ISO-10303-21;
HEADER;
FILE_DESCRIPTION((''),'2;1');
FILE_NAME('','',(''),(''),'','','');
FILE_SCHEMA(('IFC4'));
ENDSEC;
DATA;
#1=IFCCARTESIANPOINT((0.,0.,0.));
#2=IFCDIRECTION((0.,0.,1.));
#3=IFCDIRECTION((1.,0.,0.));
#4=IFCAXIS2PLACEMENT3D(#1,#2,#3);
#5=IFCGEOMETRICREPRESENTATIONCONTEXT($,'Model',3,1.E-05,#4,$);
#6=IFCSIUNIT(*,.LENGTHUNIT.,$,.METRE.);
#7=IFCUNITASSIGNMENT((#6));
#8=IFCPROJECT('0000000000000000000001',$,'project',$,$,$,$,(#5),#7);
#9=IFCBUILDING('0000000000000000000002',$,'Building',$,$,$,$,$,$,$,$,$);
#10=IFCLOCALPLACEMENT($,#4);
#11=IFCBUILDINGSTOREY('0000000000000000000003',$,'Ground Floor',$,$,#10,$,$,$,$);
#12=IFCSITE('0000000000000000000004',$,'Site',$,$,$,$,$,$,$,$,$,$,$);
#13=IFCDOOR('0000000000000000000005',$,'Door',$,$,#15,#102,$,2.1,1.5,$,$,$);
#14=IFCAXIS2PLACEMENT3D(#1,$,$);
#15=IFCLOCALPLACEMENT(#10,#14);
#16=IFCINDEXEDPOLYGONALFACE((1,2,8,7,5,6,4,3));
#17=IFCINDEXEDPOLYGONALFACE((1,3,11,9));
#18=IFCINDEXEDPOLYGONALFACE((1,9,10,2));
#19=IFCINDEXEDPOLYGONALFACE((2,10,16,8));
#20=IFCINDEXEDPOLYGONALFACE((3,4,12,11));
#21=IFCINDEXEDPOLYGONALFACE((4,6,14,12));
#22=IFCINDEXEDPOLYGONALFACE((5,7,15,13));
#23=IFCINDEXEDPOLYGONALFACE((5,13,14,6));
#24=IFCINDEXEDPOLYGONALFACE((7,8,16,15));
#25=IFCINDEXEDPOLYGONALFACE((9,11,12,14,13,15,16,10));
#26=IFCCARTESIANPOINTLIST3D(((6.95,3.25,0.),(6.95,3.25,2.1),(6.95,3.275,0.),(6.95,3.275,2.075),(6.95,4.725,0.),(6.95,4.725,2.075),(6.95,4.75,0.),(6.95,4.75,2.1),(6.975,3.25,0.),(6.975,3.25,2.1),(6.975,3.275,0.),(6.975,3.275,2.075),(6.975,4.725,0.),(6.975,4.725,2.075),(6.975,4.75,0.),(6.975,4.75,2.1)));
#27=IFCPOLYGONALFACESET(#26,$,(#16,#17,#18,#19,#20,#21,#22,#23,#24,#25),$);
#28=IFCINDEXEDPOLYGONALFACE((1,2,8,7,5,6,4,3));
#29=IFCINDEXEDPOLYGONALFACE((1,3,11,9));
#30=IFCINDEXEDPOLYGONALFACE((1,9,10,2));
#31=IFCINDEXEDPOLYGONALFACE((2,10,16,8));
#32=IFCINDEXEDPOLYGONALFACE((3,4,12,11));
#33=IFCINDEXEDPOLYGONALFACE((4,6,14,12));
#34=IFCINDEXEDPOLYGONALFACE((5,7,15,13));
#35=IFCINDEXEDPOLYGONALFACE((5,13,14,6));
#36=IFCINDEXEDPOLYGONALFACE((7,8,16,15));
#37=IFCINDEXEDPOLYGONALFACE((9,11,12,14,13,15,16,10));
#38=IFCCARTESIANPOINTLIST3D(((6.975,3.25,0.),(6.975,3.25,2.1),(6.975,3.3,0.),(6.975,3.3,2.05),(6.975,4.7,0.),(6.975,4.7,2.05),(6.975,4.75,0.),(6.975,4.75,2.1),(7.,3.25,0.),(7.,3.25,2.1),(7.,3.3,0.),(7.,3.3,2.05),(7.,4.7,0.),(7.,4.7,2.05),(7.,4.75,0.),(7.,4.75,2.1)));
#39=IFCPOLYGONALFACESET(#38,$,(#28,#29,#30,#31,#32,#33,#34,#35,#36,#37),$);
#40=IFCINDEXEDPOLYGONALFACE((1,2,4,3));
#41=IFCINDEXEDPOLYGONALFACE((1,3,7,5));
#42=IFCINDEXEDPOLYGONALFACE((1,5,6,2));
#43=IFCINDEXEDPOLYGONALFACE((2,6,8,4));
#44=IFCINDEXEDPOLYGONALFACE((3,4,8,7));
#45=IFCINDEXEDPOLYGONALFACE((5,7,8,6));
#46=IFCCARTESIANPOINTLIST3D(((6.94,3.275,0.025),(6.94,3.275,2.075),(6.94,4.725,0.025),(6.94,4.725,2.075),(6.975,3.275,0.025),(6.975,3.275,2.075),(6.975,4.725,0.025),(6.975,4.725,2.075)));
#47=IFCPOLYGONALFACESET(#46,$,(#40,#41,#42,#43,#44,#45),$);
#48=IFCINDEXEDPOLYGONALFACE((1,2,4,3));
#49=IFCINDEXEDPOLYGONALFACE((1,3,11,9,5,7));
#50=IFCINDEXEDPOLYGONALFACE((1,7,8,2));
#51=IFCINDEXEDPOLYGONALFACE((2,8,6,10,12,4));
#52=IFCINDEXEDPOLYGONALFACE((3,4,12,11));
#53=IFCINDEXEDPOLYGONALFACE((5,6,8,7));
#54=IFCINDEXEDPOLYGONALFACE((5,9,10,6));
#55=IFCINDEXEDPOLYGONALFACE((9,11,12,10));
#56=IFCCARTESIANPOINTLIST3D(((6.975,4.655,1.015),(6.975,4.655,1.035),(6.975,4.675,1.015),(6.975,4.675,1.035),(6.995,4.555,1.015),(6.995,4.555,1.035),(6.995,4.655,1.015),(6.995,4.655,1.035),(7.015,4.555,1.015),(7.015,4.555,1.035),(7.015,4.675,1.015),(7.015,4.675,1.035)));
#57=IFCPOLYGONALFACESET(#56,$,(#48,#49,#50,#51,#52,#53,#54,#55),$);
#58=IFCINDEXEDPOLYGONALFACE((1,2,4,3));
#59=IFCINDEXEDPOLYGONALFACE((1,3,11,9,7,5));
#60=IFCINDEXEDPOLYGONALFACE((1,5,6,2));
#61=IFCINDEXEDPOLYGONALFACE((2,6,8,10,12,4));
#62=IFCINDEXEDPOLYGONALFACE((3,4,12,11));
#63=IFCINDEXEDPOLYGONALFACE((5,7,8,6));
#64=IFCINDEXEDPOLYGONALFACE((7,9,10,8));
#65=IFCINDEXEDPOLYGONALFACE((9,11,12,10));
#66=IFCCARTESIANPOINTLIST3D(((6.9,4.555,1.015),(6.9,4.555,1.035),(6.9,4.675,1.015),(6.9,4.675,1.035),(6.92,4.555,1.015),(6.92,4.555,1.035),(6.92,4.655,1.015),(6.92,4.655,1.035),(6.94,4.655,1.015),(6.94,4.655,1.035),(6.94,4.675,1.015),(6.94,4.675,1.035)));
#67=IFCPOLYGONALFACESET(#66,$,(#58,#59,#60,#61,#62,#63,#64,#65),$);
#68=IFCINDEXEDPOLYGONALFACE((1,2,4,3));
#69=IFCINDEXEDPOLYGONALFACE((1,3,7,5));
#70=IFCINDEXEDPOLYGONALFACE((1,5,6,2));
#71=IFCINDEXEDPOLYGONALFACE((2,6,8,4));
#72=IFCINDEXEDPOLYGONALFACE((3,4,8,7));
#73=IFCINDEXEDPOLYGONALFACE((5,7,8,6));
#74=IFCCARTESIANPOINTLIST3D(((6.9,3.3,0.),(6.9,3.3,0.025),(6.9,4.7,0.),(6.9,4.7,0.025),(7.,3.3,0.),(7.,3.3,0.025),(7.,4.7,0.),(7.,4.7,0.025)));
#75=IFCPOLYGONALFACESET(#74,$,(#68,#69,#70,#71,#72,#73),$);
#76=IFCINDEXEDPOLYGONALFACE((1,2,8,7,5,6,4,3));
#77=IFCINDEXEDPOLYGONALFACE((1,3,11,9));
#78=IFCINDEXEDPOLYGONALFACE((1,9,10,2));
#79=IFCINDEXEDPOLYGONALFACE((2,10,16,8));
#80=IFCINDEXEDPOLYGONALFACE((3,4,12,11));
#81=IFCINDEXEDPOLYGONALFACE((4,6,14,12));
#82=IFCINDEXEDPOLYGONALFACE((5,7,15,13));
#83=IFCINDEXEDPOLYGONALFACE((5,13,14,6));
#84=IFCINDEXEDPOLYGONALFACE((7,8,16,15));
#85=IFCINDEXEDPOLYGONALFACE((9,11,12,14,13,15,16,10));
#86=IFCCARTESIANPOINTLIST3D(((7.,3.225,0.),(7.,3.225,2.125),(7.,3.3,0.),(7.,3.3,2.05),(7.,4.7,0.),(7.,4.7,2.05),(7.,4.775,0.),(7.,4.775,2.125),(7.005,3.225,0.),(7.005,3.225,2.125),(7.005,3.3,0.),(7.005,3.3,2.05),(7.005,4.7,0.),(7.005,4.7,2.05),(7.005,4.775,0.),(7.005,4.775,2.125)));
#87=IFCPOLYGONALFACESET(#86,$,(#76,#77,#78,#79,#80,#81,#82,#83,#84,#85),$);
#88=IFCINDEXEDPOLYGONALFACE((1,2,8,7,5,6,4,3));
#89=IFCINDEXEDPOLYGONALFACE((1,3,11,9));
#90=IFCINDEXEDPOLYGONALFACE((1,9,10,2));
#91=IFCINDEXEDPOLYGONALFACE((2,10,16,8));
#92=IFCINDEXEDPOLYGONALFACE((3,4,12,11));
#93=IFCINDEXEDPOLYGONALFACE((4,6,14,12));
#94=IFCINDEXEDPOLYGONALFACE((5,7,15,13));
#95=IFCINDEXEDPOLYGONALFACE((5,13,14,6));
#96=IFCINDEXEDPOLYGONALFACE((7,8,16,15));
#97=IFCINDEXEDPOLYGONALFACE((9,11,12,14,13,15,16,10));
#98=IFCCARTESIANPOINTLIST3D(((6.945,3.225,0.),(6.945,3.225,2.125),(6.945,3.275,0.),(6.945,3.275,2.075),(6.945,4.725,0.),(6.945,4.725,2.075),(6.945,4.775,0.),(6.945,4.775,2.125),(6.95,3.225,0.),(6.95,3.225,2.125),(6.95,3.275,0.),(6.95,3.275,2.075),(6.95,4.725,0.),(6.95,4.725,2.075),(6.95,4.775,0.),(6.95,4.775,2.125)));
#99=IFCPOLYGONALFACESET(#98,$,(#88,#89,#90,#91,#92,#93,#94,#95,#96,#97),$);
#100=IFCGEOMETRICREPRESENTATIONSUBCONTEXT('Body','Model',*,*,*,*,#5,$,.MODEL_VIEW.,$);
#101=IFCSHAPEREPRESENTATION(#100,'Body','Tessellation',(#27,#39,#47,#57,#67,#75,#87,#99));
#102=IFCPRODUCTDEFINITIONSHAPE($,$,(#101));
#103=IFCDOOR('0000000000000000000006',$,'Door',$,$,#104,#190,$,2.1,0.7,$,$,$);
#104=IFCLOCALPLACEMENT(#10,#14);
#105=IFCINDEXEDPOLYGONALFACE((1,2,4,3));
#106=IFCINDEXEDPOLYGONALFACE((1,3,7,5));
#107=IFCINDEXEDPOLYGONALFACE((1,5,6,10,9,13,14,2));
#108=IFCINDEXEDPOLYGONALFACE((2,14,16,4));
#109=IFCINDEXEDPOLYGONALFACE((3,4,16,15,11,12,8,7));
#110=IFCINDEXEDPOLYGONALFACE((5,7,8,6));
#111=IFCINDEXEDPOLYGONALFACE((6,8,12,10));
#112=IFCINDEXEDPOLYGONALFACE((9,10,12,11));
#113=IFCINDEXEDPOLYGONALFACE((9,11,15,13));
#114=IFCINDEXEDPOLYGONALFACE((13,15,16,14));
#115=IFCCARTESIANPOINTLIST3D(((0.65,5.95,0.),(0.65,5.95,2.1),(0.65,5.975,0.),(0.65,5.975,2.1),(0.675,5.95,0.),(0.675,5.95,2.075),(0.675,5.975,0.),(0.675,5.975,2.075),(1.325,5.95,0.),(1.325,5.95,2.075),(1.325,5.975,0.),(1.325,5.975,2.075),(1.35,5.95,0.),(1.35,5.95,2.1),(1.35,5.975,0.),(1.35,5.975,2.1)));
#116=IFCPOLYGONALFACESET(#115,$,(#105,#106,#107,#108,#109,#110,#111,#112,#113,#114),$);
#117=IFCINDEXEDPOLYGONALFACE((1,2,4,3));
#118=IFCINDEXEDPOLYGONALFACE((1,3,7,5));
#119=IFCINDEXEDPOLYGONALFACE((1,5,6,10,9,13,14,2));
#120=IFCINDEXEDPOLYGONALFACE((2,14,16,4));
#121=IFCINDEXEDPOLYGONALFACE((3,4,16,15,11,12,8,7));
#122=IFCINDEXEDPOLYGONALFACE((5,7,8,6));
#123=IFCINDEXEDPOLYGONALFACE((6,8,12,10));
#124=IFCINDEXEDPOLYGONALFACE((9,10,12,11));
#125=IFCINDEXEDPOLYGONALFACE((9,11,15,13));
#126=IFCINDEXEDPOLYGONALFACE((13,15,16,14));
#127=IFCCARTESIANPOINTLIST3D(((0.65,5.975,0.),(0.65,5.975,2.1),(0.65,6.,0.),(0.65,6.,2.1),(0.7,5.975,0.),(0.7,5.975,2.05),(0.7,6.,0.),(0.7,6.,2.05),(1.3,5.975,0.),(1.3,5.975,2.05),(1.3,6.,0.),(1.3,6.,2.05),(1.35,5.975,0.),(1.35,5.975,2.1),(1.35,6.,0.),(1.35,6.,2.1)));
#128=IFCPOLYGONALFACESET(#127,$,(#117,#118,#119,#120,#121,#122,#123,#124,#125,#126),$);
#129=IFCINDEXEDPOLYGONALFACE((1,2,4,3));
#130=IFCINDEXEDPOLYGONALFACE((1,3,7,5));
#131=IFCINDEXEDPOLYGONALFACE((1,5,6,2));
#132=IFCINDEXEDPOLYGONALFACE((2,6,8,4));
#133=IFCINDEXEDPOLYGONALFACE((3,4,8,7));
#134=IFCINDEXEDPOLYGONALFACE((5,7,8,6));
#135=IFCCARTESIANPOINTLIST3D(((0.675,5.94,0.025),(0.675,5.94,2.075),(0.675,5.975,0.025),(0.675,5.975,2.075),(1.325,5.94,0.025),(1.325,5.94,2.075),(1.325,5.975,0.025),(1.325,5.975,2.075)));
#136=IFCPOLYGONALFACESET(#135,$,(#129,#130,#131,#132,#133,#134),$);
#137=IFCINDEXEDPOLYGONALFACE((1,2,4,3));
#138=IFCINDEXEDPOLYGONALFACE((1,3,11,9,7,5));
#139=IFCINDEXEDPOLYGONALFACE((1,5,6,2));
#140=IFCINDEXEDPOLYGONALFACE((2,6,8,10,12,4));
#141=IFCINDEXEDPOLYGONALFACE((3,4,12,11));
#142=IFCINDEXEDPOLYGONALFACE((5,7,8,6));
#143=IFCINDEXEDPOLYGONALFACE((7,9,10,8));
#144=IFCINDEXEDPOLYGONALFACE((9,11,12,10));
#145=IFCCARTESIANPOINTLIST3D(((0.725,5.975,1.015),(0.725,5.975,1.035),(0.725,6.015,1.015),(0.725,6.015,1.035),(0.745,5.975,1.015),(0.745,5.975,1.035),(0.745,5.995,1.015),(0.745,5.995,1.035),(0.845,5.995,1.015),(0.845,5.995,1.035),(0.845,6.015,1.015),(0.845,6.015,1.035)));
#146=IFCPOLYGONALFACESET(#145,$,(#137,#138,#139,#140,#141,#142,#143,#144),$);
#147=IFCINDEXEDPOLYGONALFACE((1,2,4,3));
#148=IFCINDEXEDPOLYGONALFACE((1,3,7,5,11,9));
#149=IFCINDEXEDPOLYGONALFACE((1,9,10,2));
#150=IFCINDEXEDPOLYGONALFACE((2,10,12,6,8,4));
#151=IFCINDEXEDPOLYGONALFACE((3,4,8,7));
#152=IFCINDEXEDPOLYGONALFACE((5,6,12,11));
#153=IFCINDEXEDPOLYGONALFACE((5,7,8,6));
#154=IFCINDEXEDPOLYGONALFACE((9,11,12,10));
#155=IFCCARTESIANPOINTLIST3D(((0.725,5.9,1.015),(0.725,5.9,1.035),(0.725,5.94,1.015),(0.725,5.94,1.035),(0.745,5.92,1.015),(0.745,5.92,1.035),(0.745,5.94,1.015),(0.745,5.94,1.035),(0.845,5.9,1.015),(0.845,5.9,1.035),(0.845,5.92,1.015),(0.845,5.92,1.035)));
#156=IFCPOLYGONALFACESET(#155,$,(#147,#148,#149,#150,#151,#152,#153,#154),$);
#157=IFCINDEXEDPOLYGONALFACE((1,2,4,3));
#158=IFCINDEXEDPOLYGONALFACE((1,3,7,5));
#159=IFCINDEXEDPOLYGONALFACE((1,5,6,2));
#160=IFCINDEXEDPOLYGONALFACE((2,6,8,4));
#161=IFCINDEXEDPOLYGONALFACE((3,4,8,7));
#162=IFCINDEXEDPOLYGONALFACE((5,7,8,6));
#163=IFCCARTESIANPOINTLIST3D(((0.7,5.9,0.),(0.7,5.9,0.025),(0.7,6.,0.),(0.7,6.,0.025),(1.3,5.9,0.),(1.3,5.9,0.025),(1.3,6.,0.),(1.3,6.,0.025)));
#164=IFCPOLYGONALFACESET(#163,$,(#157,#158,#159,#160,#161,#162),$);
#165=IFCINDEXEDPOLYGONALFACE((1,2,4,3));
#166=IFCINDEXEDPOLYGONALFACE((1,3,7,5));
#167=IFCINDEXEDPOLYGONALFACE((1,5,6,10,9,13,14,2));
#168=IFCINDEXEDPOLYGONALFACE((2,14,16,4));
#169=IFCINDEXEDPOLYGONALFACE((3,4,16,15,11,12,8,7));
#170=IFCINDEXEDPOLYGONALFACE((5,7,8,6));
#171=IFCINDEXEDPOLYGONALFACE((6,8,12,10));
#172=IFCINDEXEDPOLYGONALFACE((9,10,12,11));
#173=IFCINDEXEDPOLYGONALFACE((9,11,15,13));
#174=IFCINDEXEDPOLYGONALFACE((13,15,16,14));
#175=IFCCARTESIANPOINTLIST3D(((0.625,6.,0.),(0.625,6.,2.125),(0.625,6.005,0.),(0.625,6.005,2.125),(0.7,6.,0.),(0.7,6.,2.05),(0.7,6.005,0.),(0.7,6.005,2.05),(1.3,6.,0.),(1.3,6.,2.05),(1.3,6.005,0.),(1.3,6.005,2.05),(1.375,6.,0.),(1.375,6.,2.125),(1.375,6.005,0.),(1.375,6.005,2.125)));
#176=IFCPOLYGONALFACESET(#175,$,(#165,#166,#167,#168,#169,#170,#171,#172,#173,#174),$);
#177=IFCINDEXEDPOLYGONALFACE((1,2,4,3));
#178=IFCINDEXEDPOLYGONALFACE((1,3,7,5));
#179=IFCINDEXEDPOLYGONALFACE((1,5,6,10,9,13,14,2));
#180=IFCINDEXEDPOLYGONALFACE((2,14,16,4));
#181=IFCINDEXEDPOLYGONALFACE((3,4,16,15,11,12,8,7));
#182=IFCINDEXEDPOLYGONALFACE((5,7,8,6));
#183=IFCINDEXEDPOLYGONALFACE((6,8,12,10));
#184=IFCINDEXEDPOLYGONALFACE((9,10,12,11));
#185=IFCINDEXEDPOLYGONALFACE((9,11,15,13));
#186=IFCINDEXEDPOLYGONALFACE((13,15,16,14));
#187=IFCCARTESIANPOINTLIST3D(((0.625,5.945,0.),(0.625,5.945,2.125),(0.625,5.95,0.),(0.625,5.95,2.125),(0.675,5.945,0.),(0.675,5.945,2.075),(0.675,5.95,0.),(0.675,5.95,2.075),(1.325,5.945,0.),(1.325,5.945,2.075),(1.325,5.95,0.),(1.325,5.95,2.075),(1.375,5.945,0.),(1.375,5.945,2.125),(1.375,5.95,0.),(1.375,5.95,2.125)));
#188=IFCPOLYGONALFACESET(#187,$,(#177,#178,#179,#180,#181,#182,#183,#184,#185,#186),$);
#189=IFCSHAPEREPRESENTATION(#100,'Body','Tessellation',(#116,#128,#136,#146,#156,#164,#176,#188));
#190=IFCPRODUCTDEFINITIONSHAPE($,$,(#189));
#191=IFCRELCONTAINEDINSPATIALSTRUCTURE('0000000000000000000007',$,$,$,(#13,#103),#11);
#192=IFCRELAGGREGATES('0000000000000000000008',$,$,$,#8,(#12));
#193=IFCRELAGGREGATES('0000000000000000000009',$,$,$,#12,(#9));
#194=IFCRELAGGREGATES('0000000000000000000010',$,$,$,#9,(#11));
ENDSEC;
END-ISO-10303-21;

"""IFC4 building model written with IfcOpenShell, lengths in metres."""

from ifc_helpers import new_model, si_unit, frame, origin_with_axes, place, context, subcontext, project, spatial, line, indexed_curve, outline, extrude, element, save


model = new_model("IFC4")

# Units and contexts
model_context = context("Model", 3, precision=1e-05, world=origin_with_axes())
body_context = subcontext(model_context, "Body", "Model", "MODEL_VIEW")
ifc_project = project(units=[si_unit("LENGTHUNIT", "METRE")], contexts=[model_context])

# Site, building, storey
site = spatial("IfcSite", under=ifc_project, Name="Site")
building = spatial("IfcBuilding", under=site, Name="Building")
storey_placement = place(None, origin_with_axes())
storey = spatial("IfcBuildingStorey", under=building, at=storey_placement, Name="Ground Floor")

# Doors
door_1_placement = place(storey_placement, frame((7.0, 3.25, 0.0), z_axis=(0.0, 0.0, 1.0), x_axis=(0.0, 1.0, 0.0)))
element("IfcDoor", 1, at=door_1_placement, inside=storey, Name="Door", OverallHeight=2.1, OverallWidth=1.5, context=body_context, shape_type="SweptSolid", body=[
    extrude(outline(indexed_curve([(0.0, 0.0), (0.0, 2.1), (1.5, 2.1), (1.5, 0.0), (1.475, 0.0), (1.475, 2.075), (0.025, 2.075), (0.025, 0.0)], segments=[line(1, 2, 3, 4, 5, 6, 7, 8, 1)])), frame((0.0, 0.025, 0.0), z_axis=(0.0, -1.0, 0.0), x_axis=(1.0, 0.0, 0.0)), (0.0, 0.0, -1.0), 0.025),
    extrude(outline(indexed_curve([(0.0, 0.0), (0.0, 2.1), (1.5, 2.1), (1.5, 0.0), (1.45, 0.0), (1.45, 2.05), (0.05, 2.05), (0.05, 0.0)], segments=[line(1, 2, 3, 4, 5, 6, 7, 8, 1)])), frame((0.0, 0.0, 0.0), z_axis=(0.0, -1.0, 0.0), x_axis=(1.0, 0.0, 0.0)), (0.0, 0.0, -1.0), 0.025),
    extrude(outline(indexed_curve([(0.0, 0.0), (1.45, 0.0), (1.45, 0.035), (0.0, 0.035)], segments=[line(1, 2, 3, 4, 1)])), frame((0.025, 0.025, 0.025), z_axis=(0.0, 0.0, 1.0), x_axis=(1.0, 0.0, 0.0)), (0.0, 0.0, 1.0), 2.05),
    extrude(outline(indexed_curve([(0.0, 0.0), (0.0, -0.04), (-0.12, -0.04), (-0.12, -0.02), (-0.02, -0.02), (-0.02, 0.0)], segments=[line(1, 2, 3, 4, 5, 6, 1)])), frame((1.425, 0.025, 1.015), z_axis=(0.0, 0.0, 1.0), x_axis=(1.0, 0.0, 0.0)), (0.0, 0.0, 1.0), 0.02),
    extrude(outline(indexed_curve([(0.0, 0.0), (0.0, 0.04), (-0.12, 0.04), (-0.12, 0.02), (-0.02, 0.02), (-0.02, 0.0)], segments=[line(1, 2, 3, 4, 5, 6, 1)])), frame((1.425, 0.06, 1.015), z_axis=(0.0, 0.0, 1.0), x_axis=(1.0, 0.0, 0.0)), (0.0, 0.0, 1.0), 0.02),
    extrude(outline(indexed_curve([(0.0, 0.0), (1.4, 0.0), (1.4, 0.1), (0.0, 0.1)], segments=[line(1, 2, 3, 4, 1)])), frame((0.05, 0.0, 0.0), z_axis=(0.0, 0.0, 1.0), x_axis=(1.0, 0.0, 0.0)), (0.0, 0.0, 1.0), 0.025),
    extrude(outline(indexed_curve([(0.0, 0.0), (0.0, 2.125), (1.55, 2.125), (1.55, 0.0), (1.475, 0.0), (1.475, 2.05), (0.075, 2.05), (0.075, 0.0)], segments=[line(1, 2, 3, 4, 5, 6, 7, 8, 1)])), frame((-0.025, -0.005, 0.0), z_axis=(0.0, -1.0, 0.0), x_axis=(1.0, 0.0, 0.0)), (0.0, 0.0, -1.0), 0.005),
    extrude(outline(indexed_curve([(0.0, 0.0), (0.0, 2.125), (1.55, 2.125), (1.55, 0.0), (1.5, 0.0), (1.5, 2.075), (0.05, 2.075), (0.05, 0.0)], segments=[line(1, 2, 3, 4, 5, 6, 7, 8, 1)])), frame((-0.025, 0.05, 0.0), z_axis=(0.0, -1.0, 0.0), x_axis=(1.0, 0.0, 0.0)), (0.0, 0.0, -1.0), 0.005),
])
door_2_placement = place(storey_placement, frame((1.35, 6.0, 0.0), z_axis=(0.0, 0.0, 1.0), x_axis=(-1.0, 0.0, 0.0)))
element("IfcDoor", 2, at=door_2_placement, inside=storey, Name="Door", OverallHeight=2.1, OverallWidth=0.7, context=body_context, shape_type="SweptSolid", body=[
    extrude(outline(indexed_curve([(0.0, 0.0), (0.0, 2.1), (0.7, 2.1), (0.7, 0.0), (0.675, 0.0), (0.675, 2.075), (0.025, 2.075), (0.025, 0.0)], segments=[line(1, 2, 3, 4, 5, 6, 7, 8, 1)])), frame((0.0, 0.025, 0.0), z_axis=(0.0, -1.0, 0.0), x_axis=(1.0, 0.0, 0.0)), (0.0, 0.0, -1.0), 0.025),
    extrude(outline(indexed_curve([(0.0, 0.0), (0.0, 2.1), (0.7, 2.1), (0.7, 0.0), (0.65, 0.0), (0.65, 2.05), (0.05, 2.05), (0.05, 0.0)], segments=[line(1, 2, 3, 4, 5, 6, 7, 8, 1)])), frame((0.0, 0.0, 0.0), z_axis=(0.0, -1.0, 0.0), x_axis=(1.0, 0.0, 0.0)), (0.0, 0.0, -1.0), 0.025),
    extrude(outline(indexed_curve([(0.0, 0.0), (0.65, 0.0), (0.65, 0.035), (0.0, 0.035)], segments=[line(1, 2, 3, 4, 1)])), frame((0.025, 0.025, 0.025), z_axis=(0.0, 0.0, 1.0), x_axis=(1.0, 0.0, 0.0)), (0.0, 0.0, 1.0), 2.05),
    extrude(outline(indexed_curve([(0.0, 0.0), (0.0, -0.04), (-0.12, -0.04), (-0.12, -0.02), (-0.02, -0.02), (-0.02, 0.0)], segments=[line(1, 2, 3, 4, 5, 6, 1)])), frame((0.625, 0.025, 1.015), z_axis=(0.0, 0.0, 1.0), x_axis=(1.0, 0.0, 0.0)), (0.0, 0.0, 1.0), 0.02),
    extrude(outline(indexed_curve([(0.0, 0.0), (0.0, 0.04), (-0.12, 0.04), (-0.12, 0.02), (-0.02, 0.02), (-0.02, 0.0)], segments=[line(1, 2, 3, 4, 5, 6, 1)])), frame((0.625, 0.06, 1.015), z_axis=(0.0, 0.0, 1.0), x_axis=(1.0, 0.0, 0.0)), (0.0, 0.0, 1.0), 0.02),
    extrude(outline(indexed_curve([(0.0, 0.0), (0.6, 0.0), (0.6, 0.1), (0.0, 0.1)], segments=[line(1, 2, 3, 4, 1)])), frame((0.05, 0.0, 0.0), z_axis=(0.0, 0.0, 1.0), x_axis=(1.0, 0.0, 0.0)), (0.0, 0.0, 1.0), 0.025),
    extrude(outline(indexed_curve([(0.0, 0.0), (0.0, 2.125), (0.75, 2.125), (0.75, 0.0), (0.675, 0.0), (0.675, 2.05), (0.075, 2.05), (0.075, 0.0)], segments=[line(1, 2, 3, 4, 5, 6, 7, 8, 1)])), frame((-0.025, -0.005, 0.0), z_axis=(0.0, -1.0, 0.0), x_axis=(1.0, 0.0, 0.0)), (0.0, 0.0, -1.0), 0.005),
    extrude(outline(indexed_curve([(0.0, 0.0), (0.0, 2.125), (0.75, 2.125), (0.75, 0.0), (0.7, 0.0), (0.7, 2.075), (0.05, 2.075), (0.05, 0.0)], segments=[line(1, 2, 3, 4, 5, 6, 7, 8, 1)])), frame((-0.025, 0.05, 0.0), z_axis=(0.0, -1.0, 0.0), x_axis=(1.0, 0.0, 0.0)), (0.0, 0.0, -1.0), 0.005),
])

save(model, "model.ifc")
